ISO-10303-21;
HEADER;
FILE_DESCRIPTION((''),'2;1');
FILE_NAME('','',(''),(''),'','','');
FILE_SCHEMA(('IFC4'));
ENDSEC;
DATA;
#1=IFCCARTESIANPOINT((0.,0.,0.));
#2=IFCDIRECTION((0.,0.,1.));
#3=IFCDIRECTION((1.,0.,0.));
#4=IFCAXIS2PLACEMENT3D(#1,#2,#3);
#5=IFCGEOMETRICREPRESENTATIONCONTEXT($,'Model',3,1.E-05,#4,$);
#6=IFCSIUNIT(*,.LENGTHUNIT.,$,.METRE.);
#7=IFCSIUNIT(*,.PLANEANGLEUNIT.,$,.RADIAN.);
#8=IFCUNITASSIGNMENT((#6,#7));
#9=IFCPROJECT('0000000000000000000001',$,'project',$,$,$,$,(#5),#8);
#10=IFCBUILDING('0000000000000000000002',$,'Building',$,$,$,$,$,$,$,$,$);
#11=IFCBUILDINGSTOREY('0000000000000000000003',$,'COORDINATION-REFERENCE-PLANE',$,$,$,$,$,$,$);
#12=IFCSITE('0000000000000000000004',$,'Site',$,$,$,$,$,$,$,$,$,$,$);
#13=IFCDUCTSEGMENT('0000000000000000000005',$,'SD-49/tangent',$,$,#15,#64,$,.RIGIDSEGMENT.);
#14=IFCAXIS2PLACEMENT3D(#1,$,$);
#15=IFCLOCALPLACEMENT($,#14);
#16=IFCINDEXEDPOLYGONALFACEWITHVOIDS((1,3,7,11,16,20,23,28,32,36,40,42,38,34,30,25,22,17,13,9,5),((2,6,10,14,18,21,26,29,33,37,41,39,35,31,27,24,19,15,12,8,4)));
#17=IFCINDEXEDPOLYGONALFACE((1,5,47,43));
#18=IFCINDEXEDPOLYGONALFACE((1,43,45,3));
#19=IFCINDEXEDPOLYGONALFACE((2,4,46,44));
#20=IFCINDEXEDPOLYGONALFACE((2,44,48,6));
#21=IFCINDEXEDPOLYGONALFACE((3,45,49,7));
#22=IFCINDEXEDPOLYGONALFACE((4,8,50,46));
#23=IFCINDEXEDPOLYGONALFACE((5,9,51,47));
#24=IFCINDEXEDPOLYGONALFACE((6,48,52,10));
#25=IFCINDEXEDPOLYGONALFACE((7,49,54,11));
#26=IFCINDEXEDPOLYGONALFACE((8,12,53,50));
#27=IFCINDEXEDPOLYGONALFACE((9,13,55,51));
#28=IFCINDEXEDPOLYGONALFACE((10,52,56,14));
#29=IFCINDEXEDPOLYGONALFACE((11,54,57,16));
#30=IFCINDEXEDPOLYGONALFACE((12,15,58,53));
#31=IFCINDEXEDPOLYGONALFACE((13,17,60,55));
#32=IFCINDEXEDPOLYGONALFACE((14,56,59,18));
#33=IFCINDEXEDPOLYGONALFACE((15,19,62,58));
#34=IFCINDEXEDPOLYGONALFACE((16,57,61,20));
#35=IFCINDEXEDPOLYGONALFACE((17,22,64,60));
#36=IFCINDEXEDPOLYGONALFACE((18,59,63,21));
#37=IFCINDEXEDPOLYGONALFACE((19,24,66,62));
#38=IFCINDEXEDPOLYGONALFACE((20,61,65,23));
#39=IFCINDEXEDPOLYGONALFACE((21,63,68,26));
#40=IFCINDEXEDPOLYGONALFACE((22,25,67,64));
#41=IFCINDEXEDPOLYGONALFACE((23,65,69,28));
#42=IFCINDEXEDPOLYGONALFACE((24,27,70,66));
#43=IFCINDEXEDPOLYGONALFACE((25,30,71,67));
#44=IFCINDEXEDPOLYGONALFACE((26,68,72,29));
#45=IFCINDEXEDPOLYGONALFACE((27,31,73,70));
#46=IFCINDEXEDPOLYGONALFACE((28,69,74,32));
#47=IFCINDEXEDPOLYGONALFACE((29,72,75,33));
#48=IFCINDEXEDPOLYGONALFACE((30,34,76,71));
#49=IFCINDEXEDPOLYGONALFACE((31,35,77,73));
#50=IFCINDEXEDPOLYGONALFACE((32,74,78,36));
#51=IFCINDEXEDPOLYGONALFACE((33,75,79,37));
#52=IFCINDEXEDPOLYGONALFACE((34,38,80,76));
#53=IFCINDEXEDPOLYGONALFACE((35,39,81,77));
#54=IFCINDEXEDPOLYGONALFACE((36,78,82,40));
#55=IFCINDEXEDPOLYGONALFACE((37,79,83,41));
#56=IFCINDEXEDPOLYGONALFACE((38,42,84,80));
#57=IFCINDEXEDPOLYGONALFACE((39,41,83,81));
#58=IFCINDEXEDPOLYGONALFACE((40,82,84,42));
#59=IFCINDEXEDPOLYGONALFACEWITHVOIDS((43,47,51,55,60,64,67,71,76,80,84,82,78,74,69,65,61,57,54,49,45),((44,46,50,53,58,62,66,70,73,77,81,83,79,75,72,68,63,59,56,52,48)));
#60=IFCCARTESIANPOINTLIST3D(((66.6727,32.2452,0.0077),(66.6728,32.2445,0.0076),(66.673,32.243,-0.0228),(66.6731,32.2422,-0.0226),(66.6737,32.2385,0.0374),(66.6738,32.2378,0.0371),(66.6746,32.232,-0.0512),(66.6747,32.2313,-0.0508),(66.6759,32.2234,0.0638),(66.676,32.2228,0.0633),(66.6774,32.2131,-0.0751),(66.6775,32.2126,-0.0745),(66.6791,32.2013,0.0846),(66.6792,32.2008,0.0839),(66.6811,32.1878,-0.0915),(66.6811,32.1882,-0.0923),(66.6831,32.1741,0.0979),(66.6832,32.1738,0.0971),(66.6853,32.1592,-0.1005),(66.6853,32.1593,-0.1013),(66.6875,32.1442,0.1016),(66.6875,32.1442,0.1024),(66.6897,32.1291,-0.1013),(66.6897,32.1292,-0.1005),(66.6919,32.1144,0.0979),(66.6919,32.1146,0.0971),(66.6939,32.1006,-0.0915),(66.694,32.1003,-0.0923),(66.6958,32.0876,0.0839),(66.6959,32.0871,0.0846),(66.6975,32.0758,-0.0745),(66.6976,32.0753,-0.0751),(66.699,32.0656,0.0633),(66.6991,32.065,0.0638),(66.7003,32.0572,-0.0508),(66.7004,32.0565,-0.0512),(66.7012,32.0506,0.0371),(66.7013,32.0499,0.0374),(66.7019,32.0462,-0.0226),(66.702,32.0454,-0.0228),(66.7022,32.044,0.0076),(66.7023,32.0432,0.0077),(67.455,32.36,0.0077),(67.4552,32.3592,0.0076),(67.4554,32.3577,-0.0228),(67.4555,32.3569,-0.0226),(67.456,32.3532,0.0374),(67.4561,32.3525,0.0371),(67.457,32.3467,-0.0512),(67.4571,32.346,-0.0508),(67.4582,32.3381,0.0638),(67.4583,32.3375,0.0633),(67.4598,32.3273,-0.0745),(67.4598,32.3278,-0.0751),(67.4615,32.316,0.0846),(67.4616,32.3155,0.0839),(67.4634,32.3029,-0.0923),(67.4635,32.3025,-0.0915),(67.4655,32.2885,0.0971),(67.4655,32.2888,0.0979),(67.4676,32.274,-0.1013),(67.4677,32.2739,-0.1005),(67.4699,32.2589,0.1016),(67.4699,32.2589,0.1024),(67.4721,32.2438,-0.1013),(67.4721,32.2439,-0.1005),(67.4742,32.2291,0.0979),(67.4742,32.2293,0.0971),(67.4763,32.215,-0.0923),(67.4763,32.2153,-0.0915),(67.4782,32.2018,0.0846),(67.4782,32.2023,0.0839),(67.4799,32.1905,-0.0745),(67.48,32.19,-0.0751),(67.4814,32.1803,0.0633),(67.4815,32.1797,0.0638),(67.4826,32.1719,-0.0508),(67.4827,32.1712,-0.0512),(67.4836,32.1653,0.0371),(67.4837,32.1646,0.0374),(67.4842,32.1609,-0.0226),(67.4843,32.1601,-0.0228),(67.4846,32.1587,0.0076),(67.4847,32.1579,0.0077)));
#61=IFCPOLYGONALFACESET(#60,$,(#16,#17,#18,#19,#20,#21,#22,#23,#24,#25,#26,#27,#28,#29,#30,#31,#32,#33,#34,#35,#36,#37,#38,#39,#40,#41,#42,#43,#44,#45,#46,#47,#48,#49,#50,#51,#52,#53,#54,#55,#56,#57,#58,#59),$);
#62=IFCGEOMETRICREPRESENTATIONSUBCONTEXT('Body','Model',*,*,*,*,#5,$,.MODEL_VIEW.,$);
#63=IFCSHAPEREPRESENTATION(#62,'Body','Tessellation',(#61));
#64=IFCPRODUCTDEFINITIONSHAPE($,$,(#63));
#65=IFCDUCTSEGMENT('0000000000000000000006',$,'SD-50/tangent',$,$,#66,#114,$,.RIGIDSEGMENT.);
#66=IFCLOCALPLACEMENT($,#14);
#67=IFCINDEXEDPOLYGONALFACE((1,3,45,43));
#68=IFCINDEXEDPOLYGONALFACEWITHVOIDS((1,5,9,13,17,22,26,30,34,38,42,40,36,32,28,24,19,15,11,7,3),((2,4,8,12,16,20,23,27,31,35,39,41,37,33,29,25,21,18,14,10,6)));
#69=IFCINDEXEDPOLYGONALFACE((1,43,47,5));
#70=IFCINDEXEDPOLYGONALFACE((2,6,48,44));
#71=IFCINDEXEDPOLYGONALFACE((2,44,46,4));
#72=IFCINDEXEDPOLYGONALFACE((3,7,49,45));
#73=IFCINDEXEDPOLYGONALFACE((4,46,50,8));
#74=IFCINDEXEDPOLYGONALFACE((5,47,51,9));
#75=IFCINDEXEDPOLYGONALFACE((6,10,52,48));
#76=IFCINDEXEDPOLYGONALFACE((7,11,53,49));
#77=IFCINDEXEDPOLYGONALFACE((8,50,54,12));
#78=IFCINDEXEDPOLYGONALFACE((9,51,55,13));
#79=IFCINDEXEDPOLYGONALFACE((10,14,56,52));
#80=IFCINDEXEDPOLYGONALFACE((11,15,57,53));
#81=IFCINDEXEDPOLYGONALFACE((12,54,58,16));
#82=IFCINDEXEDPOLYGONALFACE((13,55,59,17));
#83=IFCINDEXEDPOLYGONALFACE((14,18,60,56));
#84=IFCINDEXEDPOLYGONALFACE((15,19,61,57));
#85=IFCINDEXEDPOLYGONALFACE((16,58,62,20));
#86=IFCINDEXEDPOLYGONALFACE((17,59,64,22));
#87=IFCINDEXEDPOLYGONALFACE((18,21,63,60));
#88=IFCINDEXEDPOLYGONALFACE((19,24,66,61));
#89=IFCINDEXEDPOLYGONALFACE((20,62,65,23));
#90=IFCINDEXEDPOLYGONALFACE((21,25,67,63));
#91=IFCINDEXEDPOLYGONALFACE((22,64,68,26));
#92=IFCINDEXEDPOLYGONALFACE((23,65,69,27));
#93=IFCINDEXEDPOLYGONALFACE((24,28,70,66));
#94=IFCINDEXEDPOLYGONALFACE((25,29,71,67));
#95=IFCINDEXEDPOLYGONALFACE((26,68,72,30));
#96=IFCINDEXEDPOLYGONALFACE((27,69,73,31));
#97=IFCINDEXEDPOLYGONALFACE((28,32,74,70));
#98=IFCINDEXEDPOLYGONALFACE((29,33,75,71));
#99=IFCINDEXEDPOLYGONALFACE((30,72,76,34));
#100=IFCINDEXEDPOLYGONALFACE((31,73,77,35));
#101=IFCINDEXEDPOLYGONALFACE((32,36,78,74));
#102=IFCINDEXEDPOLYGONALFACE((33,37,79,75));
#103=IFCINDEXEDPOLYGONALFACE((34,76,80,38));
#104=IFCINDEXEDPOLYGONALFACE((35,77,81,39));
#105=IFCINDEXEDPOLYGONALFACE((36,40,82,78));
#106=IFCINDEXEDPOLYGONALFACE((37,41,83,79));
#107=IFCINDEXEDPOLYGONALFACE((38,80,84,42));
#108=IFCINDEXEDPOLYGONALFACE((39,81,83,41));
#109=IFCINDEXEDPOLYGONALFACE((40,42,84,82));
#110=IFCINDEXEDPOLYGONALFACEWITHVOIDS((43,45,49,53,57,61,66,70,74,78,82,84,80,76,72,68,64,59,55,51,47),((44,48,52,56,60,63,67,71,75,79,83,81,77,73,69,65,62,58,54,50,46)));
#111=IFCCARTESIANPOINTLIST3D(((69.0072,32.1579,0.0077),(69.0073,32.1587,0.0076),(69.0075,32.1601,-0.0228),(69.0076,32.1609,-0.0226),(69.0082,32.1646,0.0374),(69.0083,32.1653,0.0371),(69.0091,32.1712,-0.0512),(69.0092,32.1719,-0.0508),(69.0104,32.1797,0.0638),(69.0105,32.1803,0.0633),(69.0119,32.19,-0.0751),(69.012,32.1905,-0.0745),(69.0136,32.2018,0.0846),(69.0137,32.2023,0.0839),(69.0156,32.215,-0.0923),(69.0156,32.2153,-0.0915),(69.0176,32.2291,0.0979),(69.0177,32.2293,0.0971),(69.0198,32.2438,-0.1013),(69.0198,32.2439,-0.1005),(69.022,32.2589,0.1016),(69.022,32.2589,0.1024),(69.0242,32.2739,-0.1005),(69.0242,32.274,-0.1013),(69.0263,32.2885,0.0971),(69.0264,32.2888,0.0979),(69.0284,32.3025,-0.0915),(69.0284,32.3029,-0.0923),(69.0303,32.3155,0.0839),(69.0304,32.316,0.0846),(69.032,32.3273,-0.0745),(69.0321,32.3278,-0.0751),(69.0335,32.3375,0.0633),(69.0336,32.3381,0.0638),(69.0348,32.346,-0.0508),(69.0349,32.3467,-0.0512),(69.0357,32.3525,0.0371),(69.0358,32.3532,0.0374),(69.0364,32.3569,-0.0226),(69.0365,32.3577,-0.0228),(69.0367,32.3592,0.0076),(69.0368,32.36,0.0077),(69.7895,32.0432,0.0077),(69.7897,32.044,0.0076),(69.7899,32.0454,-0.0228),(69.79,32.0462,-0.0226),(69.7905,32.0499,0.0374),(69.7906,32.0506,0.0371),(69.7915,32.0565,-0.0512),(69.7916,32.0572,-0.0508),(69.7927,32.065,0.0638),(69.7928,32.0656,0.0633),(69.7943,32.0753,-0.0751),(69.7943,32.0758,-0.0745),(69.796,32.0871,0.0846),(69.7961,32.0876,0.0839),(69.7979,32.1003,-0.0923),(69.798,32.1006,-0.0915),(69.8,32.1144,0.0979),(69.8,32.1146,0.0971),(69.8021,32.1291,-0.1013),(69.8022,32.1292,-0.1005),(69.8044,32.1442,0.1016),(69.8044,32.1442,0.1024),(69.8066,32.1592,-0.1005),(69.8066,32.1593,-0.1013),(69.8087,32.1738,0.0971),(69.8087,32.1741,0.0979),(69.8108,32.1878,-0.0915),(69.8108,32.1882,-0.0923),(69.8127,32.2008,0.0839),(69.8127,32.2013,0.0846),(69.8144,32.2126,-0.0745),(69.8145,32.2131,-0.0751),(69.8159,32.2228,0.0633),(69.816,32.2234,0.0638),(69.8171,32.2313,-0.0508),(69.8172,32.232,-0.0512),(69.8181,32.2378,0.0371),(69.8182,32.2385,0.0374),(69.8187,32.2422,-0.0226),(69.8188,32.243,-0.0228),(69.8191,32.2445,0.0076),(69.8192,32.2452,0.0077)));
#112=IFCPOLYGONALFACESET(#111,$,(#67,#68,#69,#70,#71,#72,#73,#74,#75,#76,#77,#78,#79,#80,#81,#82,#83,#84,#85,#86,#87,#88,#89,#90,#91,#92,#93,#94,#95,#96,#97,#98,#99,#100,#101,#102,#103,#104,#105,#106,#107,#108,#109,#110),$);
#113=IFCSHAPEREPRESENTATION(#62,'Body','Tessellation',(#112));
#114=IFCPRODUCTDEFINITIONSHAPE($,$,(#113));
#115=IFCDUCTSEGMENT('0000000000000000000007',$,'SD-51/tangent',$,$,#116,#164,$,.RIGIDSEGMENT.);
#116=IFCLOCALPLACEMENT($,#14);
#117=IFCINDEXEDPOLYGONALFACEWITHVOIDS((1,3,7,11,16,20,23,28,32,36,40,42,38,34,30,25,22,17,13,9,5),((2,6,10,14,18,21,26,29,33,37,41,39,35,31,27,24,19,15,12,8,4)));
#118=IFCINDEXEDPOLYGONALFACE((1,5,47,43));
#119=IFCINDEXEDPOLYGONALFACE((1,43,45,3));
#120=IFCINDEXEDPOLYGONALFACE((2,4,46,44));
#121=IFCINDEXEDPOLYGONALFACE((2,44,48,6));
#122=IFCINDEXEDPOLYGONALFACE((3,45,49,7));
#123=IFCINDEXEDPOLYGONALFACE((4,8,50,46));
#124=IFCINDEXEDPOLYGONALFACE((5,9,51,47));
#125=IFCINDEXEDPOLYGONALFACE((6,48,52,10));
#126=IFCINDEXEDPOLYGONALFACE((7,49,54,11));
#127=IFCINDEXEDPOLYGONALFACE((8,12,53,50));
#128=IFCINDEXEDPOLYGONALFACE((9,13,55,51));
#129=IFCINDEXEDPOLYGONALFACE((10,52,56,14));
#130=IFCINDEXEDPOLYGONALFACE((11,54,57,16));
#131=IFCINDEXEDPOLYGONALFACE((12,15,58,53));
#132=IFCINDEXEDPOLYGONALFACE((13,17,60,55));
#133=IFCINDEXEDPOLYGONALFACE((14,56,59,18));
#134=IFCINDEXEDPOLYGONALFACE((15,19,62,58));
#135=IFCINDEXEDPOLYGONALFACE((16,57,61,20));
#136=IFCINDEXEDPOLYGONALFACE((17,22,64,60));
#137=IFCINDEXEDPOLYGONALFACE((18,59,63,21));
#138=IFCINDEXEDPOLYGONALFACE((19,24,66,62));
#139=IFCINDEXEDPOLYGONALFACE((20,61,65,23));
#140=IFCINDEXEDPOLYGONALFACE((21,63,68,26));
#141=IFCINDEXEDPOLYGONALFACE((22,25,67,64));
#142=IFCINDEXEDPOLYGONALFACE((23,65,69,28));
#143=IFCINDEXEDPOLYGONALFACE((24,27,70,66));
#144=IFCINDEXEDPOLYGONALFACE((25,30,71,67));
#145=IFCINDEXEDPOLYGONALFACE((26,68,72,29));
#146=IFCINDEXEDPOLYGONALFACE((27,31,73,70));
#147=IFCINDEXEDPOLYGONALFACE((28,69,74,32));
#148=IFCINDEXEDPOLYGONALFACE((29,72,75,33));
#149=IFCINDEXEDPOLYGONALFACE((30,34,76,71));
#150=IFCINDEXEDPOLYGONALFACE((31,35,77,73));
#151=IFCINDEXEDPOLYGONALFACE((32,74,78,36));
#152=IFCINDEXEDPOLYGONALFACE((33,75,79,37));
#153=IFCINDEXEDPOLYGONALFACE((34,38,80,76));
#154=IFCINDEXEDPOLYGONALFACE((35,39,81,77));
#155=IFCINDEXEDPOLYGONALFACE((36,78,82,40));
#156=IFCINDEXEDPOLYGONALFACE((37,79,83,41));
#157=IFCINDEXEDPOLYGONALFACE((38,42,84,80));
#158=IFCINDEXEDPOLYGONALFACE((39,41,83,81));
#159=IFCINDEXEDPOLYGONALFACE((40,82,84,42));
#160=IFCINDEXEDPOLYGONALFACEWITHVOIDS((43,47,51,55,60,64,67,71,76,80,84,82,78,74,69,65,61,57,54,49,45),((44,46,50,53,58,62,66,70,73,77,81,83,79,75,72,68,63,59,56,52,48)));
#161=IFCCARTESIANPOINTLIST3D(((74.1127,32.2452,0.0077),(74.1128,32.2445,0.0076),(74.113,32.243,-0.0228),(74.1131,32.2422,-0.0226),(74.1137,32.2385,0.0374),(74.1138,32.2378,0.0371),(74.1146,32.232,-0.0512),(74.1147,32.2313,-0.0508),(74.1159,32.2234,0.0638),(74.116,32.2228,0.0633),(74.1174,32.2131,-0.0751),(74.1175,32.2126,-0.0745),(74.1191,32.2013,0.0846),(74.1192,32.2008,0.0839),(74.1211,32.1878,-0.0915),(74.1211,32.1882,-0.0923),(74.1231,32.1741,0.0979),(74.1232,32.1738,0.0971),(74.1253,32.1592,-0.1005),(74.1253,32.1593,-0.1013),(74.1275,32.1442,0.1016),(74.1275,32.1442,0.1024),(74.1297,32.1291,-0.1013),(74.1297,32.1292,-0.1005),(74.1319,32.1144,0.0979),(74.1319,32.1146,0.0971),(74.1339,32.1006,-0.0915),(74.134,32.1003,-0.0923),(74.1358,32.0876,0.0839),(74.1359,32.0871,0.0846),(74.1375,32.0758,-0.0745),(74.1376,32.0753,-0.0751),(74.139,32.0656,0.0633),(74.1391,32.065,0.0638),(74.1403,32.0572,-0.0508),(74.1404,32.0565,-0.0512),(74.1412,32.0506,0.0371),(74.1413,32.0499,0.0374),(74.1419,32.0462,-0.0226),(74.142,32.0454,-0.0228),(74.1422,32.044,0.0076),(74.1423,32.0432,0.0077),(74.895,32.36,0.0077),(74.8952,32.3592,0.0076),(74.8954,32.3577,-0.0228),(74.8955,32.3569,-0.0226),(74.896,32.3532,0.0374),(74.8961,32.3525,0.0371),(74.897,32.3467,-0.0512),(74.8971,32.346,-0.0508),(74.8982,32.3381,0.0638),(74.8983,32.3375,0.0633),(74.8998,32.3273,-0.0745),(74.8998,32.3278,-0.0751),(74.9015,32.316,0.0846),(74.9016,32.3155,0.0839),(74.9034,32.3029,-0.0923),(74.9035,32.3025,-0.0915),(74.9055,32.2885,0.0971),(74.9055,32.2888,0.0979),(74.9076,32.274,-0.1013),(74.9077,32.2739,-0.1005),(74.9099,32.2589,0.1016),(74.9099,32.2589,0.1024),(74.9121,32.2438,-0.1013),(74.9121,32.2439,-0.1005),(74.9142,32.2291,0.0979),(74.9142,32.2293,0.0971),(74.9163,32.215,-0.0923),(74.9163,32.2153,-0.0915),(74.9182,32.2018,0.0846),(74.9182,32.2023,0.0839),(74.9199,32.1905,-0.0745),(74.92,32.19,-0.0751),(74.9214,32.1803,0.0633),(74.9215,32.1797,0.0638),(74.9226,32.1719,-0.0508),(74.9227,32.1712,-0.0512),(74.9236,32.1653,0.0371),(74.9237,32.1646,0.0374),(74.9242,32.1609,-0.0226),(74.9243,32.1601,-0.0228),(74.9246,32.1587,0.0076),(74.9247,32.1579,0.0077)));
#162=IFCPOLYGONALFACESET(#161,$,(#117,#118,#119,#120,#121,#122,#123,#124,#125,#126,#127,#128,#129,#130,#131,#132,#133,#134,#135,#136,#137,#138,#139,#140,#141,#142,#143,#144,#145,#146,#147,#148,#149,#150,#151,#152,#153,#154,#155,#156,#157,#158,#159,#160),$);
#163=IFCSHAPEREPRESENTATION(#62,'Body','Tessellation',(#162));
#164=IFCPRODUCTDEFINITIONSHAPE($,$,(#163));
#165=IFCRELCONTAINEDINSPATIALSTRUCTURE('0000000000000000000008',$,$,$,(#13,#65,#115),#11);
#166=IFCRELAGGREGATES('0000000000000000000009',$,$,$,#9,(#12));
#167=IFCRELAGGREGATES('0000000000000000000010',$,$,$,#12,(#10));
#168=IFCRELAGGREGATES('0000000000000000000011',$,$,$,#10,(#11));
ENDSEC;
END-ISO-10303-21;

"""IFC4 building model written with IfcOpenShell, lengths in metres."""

from ifc_helpers import new_model, si_unit, frame, origin_with_axes, place, context, subcontext, project, spatial, hollow_circle, extrude, element, save


model = new_model("IFC4")

# Units and contexts
model_context = context("Model", 3, precision=1e-05, world=origin_with_axes())
body_context_1 = subcontext(model_context, "Body", "Model", "MODEL_VIEW")
ifc_project = project(units=[si_unit("LENGTHUNIT", "METRE"), si_unit("PLANEANGLEUNIT", "RADIAN")], contexts=[model_context])

# Site, building, storey
site = spatial("IfcSite", under=ifc_project, Name="Site")
building = spatial("IfcBuilding", under=site, Name="Building")
storey = spatial("IfcBuildingStorey", under=building, Name="COORDINATION-REFERENCE-PLANE")

# Duct segment
duct_segment_1_placement = place(None, frame((67.4699, 32.2589, 0.0), z_axis=(-0.989423, -0.145062, 0.0), x_axis=(0.0, 0.0, 1.0)))
element("IfcDuctSegment", 1, at=duct_segment_1_placement, inside=storey, Name="SD-49/tangent", PredefinedType="RIGIDSEGMENT", context=body_context_1, shape_type="SweptSolid", body=[
    extrude(hollow_circle(Radius=0.1024, WallThickness=0.0008), origin_with_axes(), (0.0, 0.0, 1.0), 0.7907),
])

# Duct segment
duct_segment_2_placement = place(None, frame((69.022, 32.2589, 0.0), z_axis=(0.989423, -0.145062, 0.0), x_axis=(0.0, 0.0, 1.0)))
element("IfcDuctSegment", 2, at=duct_segment_2_placement, inside=storey, Name="SD-50/tangent", PredefinedType="RIGIDSEGMENT", context=body_context_1, shape_type="SweptSolid", body=[
    extrude(hollow_circle(Radius=0.1024, WallThickness=0.0008), origin_with_axes(), (0.0, 0.0, 1.0), 0.7907),
])

# Duct segment
duct_segment_3_placement = place(None, frame((74.9099, 32.2589, 0.0), z_axis=(-0.989423, -0.145062, 0.0), x_axis=(0.0, 0.0, 1.0)))
element("IfcDuctSegment", 3, at=duct_segment_3_placement, inside=storey, Name="SD-51/tangent", PredefinedType="RIGIDSEGMENT", context=body_context_1, shape_type="SweptSolid", body=[
    extrude(hollow_circle(Radius=0.1024, WallThickness=0.0008), origin_with_axes(), (0.0, 0.0, 1.0), 0.7907),
])

save(model, "model.ifc")
